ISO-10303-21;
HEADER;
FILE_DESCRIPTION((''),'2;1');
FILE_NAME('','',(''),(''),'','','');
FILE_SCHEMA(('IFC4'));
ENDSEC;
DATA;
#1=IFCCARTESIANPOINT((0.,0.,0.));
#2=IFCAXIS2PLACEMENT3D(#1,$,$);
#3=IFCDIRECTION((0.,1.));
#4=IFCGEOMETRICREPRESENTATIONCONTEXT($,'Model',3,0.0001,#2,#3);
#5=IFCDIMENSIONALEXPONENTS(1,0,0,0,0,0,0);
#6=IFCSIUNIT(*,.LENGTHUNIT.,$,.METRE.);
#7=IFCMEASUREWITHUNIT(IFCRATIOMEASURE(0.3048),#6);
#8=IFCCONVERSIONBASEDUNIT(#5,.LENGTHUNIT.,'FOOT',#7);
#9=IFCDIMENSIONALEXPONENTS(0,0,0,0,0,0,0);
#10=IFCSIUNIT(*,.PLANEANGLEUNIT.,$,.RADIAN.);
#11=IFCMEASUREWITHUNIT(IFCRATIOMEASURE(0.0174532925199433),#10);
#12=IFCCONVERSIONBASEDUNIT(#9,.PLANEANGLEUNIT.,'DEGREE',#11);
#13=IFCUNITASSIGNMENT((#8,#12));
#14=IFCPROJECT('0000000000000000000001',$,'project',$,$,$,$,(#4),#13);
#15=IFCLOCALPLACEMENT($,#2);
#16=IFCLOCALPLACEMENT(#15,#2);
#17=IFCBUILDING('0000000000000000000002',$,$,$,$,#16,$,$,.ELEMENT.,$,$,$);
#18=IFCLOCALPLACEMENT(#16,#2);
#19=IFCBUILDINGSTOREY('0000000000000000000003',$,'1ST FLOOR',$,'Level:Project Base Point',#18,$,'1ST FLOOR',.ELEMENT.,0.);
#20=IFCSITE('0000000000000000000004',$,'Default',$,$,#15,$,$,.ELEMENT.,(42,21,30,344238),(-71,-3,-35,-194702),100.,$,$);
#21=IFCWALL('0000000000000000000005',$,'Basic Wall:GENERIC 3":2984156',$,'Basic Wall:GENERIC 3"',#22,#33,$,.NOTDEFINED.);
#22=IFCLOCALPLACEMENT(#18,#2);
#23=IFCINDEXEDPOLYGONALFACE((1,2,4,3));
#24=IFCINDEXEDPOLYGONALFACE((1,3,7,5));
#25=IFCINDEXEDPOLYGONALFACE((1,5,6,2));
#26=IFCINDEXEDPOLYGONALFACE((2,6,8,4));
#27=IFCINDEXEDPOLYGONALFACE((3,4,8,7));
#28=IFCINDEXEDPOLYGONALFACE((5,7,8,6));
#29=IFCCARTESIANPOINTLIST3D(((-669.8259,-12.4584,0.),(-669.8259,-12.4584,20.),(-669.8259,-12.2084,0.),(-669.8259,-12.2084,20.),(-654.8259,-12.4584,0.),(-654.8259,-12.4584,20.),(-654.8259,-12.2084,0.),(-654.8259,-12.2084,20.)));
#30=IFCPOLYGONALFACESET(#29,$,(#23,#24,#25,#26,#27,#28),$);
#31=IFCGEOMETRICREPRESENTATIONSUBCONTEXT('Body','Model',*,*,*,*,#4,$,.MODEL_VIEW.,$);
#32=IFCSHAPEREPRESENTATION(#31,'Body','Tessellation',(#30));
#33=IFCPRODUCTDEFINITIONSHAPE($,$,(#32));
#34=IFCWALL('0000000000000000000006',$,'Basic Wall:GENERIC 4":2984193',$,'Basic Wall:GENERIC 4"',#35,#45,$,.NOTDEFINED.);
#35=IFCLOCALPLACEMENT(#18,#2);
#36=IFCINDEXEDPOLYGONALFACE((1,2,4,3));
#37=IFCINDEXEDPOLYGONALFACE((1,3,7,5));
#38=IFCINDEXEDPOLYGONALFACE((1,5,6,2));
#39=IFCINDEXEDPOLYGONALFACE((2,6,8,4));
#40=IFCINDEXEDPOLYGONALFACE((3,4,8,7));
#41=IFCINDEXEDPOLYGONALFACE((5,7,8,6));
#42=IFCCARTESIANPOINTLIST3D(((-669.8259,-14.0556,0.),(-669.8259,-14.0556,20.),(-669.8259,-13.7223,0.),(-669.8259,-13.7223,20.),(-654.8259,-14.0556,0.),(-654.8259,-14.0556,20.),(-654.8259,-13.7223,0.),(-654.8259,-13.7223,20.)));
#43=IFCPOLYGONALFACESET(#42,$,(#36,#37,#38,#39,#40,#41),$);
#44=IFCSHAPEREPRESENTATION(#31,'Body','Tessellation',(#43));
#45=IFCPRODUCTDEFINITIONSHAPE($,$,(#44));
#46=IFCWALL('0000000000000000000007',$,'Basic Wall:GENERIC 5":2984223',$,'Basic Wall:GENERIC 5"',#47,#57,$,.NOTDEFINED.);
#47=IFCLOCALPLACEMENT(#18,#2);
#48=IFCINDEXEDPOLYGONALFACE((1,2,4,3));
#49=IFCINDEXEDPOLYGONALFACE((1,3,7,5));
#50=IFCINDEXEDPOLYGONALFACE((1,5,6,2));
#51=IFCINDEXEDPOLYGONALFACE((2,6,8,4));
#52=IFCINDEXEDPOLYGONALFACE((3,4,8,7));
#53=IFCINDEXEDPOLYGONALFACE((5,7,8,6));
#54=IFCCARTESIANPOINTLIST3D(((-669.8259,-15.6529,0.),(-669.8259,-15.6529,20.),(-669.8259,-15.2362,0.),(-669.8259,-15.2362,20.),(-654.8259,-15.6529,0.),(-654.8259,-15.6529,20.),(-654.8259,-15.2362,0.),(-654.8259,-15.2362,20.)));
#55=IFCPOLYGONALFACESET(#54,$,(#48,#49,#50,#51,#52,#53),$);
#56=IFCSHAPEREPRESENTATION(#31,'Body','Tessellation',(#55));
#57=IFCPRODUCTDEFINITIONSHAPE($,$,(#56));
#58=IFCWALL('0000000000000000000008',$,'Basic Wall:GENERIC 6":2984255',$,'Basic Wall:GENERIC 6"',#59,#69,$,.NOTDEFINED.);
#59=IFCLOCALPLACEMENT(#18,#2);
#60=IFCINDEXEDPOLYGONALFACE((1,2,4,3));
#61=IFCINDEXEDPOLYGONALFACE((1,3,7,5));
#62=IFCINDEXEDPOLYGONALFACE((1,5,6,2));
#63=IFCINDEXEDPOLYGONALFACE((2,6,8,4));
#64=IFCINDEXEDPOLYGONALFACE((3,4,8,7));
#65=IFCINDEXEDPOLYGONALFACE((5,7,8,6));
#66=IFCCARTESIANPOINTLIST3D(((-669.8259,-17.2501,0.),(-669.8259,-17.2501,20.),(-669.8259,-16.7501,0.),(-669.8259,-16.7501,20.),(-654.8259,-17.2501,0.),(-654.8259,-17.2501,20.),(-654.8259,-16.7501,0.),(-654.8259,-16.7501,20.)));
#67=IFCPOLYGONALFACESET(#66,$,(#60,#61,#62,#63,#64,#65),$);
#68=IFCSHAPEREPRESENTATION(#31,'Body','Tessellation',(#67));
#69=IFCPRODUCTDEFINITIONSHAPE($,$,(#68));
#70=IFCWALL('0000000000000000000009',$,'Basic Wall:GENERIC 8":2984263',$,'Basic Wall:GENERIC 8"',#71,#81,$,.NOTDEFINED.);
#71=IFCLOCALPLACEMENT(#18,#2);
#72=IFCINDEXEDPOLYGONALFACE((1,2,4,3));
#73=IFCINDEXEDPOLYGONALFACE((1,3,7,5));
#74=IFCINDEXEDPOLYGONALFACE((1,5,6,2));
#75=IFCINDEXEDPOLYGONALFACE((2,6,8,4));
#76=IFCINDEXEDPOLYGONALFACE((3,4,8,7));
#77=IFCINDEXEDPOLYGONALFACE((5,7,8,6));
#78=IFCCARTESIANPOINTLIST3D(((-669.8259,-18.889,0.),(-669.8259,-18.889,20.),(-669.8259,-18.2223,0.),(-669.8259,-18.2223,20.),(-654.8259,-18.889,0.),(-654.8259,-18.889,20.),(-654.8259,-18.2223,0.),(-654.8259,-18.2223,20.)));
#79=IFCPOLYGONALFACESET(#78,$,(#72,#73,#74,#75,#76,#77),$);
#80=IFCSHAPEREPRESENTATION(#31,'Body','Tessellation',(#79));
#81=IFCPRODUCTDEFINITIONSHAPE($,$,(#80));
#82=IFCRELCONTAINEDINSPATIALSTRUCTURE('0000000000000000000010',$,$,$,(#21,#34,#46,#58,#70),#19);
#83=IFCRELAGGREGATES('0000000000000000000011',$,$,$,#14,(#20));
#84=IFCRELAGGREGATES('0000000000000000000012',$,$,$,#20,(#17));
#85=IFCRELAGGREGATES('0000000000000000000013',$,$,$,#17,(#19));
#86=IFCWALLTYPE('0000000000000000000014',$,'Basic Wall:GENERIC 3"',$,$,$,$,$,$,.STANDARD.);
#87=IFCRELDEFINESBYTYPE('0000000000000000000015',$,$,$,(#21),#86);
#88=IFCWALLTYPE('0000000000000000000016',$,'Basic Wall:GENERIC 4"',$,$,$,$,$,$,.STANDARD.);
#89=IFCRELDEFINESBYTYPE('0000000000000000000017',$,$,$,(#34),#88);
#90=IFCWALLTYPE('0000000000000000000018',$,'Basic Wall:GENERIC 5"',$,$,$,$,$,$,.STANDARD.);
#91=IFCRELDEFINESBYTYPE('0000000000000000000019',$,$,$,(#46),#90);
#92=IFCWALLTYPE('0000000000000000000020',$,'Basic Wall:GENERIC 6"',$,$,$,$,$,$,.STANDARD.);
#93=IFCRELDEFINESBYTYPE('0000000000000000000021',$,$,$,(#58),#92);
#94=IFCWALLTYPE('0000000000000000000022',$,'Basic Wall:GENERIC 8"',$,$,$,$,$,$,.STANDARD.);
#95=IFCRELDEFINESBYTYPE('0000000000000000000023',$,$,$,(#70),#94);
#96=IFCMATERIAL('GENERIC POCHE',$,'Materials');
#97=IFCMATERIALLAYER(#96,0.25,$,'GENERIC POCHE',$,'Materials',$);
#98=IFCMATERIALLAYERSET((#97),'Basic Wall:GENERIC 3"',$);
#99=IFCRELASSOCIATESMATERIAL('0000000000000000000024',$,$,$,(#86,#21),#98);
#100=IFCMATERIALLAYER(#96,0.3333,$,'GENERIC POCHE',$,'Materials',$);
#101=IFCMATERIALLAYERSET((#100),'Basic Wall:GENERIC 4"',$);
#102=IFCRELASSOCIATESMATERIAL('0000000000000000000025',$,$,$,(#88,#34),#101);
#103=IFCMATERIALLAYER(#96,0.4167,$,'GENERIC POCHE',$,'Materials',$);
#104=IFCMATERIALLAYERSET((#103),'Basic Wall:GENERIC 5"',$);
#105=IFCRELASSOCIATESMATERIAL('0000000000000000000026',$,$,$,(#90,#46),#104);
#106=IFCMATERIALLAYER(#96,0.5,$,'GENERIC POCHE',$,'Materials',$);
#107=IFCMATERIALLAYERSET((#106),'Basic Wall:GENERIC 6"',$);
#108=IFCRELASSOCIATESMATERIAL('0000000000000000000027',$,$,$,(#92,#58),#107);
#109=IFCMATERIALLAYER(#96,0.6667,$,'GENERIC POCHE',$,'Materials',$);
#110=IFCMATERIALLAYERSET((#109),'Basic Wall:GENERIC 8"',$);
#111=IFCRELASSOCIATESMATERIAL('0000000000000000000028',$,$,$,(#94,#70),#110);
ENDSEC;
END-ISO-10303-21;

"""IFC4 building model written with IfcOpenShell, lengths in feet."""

from ifc_helpers import new_model, entity, si_unit, converted_unit, direction, frame, frame_2d, origin, place, context, subcontext, project, spatial, rectangle, extrude, material, layer, layer_set, layer_usage, type_object, element, save


model = new_model("IFC4")

# Units and contexts
model_context = context("Model", 3, precision=0.0001, world=origin(), true_north=direction((0.0, 1.0)))
body_context = subcontext(model_context, "Body", "Model", "MODEL_VIEW")
ifc_project = project(units=[converted_unit("LENGTHUNIT", "FOOT", entity("IfcRatioMeasure", 0.3048), si_unit("LENGTHUNIT", "METRE"), dimensions=[1, 0, 0, 0, 0, 0, 0]), converted_unit("PLANEANGLEUNIT", "DEGREE", entity("IfcRatioMeasure", 0.0174532925199433), si_unit("PLANEANGLEUNIT", "RADIAN"), dimensions=[0, 0, 0, 0, 0, 0, 0])], contexts=[model_context])

# Site, building, storey
site_placement = place(None, origin())
site = spatial("IfcSite", under=ifc_project, at=site_placement, Name="Default", CompositionType="ELEMENT", RefLatitude=(42, 21, 30, 344238), RefLongitude=(-71, -3, -35, -194702), RefElevation=100.0)
building_placement = place(site_placement, origin())
building = spatial("IfcBuilding", under=site, at=building_placement, CompositionType="ELEMENT")
storey_placement = place(building_placement, origin())
storey = spatial("IfcBuildingStorey", under=building, at=storey_placement, Name="1ST FLOOR", ObjectType="Level:Project Base Point", LongName="1ST FLOOR", CompositionType="ELEMENT", Elevation=0.0)

# Walls
ifc_material_1 = material(Name="GENERIC POCHE", Category="Materials")
ifc_layer_1 = layer(ifc_material_1, 0.25, Name="GENERIC POCHE", Category="Materials")
ifc_layer_set_1 = layer_set([ifc_layer_1], Name="Basic Wall:GENERIC 3\"")
ifc_layer_usage_1 = layer_usage(ifc_layer_set_1, "AXIS2", "NEGATIVE", 0.125)
wall_type_1 = type_object("IfcWallType", Name="Basic Wall:GENERIC 3\"", PredefinedType="STANDARD", material=ifc_layer_set_1)
wall_1_placement = place(storey_placement, frame((-669.8259, -12.3334, 0.0)))
element("IfcWall", 1, at=wall_1_placement, inside=storey, type_object=wall_type_1, material=ifc_layer_usage_1, Name="Basic Wall:GENERIC 3\":2984156", ObjectType="Basic Wall:GENERIC 3\"", PredefinedType="NOTDEFINED", context=body_context, shape_type="SweptSolid", body=[
    extrude(rectangle(XDim=15.0, YDim=0.25, at=frame_2d((7.5, 0.0), x_axis=(-1.0, 0.0))), origin(), (0.0, 0.0, 1.0), 20.0),
])
ifc_layer_2 = layer(ifc_material_1, 0.3333, Name="GENERIC POCHE", Category="Materials")
ifc_layer_set_2 = layer_set([ifc_layer_2], Name="Basic Wall:GENERIC 4\"")
ifc_layer_usage_2 = layer_usage(ifc_layer_set_2, "AXIS2", "NEGATIVE", 0.1667)
wall_type_2 = type_object("IfcWallType", Name="Basic Wall:GENERIC 4\"", PredefinedType="STANDARD", material=ifc_layer_set_2)
wall_2_placement = place(storey_placement, frame((-669.8259, -13.889, 0.0)))
element("IfcWall", 2, at=wall_2_placement, inside=storey, type_object=wall_type_2, material=ifc_layer_usage_2, Name="Basic Wall:GENERIC 4\":2984193", ObjectType="Basic Wall:GENERIC 4\"", PredefinedType="NOTDEFINED", context=body_context, shape_type="SweptSolid", body=[
    extrude(rectangle(XDim=15.0, YDim=0.3333, at=frame_2d((7.5, 0.0), x_axis=(-1.0, 0.0))), origin(), (0.0, 0.0, 1.0), 20.0),
])
ifc_layer_3 = layer(ifc_material_1, 0.4167, Name="GENERIC POCHE", Category="Materials")
ifc_layer_set_3 = layer_set([ifc_layer_3], Name="Basic Wall:GENERIC 5\"")
ifc_layer_usage_3 = layer_usage(ifc_layer_set_3, "AXIS2", "NEGATIVE", 0.2083)
wall_type_3 = type_object("IfcWallType", Name="Basic Wall:GENERIC 5\"", PredefinedType="STANDARD", material=ifc_layer_set_3)
wall_3_placement = place(storey_placement, frame((-669.8259, -15.4445, 0.0)))
element("IfcWall", 3, at=wall_3_placement, inside=storey, type_object=wall_type_3, material=ifc_layer_usage_3, Name="Basic Wall:GENERIC 5\":2984223", ObjectType="Basic Wall:GENERIC 5\"", PredefinedType="NOTDEFINED", context=body_context, shape_type="SweptSolid", body=[
    extrude(rectangle(XDim=15.0, YDim=0.4167, at=frame_2d((7.5, 0.0), x_axis=(-1.0, 0.0))), origin(), (0.0, 0.0, 1.0), 20.0),
])
ifc_layer_4 = layer(ifc_material_1, 0.5, Name="GENERIC POCHE", Category="Materials")
ifc_layer_set_4 = layer_set([ifc_layer_4], Name="Basic Wall:GENERIC 6\"")
ifc_layer_usage_4 = layer_usage(ifc_layer_set_4, "AXIS2", "NEGATIVE", 0.25)
wall_type_4 = type_object("IfcWallType", Name="Basic Wall:GENERIC 6\"", PredefinedType="STANDARD", material=ifc_layer_set_4)
wall_4_placement = place(storey_placement, frame((-669.8259, -17.0001, 0.0)))
element("IfcWall", 4, at=wall_4_placement, inside=storey, type_object=wall_type_4, material=ifc_layer_usage_4, Name="Basic Wall:GENERIC 6\":2984255", ObjectType="Basic Wall:GENERIC 6\"", PredefinedType="NOTDEFINED", context=body_context, shape_type="SweptSolid", body=[
    extrude(rectangle(XDim=15.0, YDim=0.5, at=frame_2d((7.5, 0.0), x_axis=(-1.0, 0.0))), origin(), (0.0, 0.0, 1.0), 20.0),
])
ifc_layer_5 = layer(ifc_material_1, 0.6667, Name="GENERIC POCHE", Category="Materials")
ifc_layer_set_5 = layer_set([ifc_layer_5], Name="Basic Wall:GENERIC 8\"")
ifc_layer_usage_5 = layer_usage(ifc_layer_set_5, "AXIS2", "NEGATIVE", 0.3333)
wall_type_5 = type_object("IfcWallType", Name="Basic Wall:GENERIC 8\"", PredefinedType="STANDARD", material=ifc_layer_set_5)
wall_5_placement = place(storey_placement, frame((-669.8259, -18.5556, 0.0)))
element("IfcWall", 5, at=wall_5_placement, inside=storey, type_object=wall_type_5, material=ifc_layer_usage_5, Name="Basic Wall:GENERIC 8\":2984263", ObjectType="Basic Wall:GENERIC 8\"", PredefinedType="NOTDEFINED", context=body_context, shape_type="SweptSolid", body=[
    extrude(rectangle(XDim=15.0, YDim=0.6667, at=frame_2d((7.5, 0.0), x_axis=(-1.0, 0.0))), origin(), (0.0, 0.0, 1.0), 20.0),
])

save(model, "model.ifc")
